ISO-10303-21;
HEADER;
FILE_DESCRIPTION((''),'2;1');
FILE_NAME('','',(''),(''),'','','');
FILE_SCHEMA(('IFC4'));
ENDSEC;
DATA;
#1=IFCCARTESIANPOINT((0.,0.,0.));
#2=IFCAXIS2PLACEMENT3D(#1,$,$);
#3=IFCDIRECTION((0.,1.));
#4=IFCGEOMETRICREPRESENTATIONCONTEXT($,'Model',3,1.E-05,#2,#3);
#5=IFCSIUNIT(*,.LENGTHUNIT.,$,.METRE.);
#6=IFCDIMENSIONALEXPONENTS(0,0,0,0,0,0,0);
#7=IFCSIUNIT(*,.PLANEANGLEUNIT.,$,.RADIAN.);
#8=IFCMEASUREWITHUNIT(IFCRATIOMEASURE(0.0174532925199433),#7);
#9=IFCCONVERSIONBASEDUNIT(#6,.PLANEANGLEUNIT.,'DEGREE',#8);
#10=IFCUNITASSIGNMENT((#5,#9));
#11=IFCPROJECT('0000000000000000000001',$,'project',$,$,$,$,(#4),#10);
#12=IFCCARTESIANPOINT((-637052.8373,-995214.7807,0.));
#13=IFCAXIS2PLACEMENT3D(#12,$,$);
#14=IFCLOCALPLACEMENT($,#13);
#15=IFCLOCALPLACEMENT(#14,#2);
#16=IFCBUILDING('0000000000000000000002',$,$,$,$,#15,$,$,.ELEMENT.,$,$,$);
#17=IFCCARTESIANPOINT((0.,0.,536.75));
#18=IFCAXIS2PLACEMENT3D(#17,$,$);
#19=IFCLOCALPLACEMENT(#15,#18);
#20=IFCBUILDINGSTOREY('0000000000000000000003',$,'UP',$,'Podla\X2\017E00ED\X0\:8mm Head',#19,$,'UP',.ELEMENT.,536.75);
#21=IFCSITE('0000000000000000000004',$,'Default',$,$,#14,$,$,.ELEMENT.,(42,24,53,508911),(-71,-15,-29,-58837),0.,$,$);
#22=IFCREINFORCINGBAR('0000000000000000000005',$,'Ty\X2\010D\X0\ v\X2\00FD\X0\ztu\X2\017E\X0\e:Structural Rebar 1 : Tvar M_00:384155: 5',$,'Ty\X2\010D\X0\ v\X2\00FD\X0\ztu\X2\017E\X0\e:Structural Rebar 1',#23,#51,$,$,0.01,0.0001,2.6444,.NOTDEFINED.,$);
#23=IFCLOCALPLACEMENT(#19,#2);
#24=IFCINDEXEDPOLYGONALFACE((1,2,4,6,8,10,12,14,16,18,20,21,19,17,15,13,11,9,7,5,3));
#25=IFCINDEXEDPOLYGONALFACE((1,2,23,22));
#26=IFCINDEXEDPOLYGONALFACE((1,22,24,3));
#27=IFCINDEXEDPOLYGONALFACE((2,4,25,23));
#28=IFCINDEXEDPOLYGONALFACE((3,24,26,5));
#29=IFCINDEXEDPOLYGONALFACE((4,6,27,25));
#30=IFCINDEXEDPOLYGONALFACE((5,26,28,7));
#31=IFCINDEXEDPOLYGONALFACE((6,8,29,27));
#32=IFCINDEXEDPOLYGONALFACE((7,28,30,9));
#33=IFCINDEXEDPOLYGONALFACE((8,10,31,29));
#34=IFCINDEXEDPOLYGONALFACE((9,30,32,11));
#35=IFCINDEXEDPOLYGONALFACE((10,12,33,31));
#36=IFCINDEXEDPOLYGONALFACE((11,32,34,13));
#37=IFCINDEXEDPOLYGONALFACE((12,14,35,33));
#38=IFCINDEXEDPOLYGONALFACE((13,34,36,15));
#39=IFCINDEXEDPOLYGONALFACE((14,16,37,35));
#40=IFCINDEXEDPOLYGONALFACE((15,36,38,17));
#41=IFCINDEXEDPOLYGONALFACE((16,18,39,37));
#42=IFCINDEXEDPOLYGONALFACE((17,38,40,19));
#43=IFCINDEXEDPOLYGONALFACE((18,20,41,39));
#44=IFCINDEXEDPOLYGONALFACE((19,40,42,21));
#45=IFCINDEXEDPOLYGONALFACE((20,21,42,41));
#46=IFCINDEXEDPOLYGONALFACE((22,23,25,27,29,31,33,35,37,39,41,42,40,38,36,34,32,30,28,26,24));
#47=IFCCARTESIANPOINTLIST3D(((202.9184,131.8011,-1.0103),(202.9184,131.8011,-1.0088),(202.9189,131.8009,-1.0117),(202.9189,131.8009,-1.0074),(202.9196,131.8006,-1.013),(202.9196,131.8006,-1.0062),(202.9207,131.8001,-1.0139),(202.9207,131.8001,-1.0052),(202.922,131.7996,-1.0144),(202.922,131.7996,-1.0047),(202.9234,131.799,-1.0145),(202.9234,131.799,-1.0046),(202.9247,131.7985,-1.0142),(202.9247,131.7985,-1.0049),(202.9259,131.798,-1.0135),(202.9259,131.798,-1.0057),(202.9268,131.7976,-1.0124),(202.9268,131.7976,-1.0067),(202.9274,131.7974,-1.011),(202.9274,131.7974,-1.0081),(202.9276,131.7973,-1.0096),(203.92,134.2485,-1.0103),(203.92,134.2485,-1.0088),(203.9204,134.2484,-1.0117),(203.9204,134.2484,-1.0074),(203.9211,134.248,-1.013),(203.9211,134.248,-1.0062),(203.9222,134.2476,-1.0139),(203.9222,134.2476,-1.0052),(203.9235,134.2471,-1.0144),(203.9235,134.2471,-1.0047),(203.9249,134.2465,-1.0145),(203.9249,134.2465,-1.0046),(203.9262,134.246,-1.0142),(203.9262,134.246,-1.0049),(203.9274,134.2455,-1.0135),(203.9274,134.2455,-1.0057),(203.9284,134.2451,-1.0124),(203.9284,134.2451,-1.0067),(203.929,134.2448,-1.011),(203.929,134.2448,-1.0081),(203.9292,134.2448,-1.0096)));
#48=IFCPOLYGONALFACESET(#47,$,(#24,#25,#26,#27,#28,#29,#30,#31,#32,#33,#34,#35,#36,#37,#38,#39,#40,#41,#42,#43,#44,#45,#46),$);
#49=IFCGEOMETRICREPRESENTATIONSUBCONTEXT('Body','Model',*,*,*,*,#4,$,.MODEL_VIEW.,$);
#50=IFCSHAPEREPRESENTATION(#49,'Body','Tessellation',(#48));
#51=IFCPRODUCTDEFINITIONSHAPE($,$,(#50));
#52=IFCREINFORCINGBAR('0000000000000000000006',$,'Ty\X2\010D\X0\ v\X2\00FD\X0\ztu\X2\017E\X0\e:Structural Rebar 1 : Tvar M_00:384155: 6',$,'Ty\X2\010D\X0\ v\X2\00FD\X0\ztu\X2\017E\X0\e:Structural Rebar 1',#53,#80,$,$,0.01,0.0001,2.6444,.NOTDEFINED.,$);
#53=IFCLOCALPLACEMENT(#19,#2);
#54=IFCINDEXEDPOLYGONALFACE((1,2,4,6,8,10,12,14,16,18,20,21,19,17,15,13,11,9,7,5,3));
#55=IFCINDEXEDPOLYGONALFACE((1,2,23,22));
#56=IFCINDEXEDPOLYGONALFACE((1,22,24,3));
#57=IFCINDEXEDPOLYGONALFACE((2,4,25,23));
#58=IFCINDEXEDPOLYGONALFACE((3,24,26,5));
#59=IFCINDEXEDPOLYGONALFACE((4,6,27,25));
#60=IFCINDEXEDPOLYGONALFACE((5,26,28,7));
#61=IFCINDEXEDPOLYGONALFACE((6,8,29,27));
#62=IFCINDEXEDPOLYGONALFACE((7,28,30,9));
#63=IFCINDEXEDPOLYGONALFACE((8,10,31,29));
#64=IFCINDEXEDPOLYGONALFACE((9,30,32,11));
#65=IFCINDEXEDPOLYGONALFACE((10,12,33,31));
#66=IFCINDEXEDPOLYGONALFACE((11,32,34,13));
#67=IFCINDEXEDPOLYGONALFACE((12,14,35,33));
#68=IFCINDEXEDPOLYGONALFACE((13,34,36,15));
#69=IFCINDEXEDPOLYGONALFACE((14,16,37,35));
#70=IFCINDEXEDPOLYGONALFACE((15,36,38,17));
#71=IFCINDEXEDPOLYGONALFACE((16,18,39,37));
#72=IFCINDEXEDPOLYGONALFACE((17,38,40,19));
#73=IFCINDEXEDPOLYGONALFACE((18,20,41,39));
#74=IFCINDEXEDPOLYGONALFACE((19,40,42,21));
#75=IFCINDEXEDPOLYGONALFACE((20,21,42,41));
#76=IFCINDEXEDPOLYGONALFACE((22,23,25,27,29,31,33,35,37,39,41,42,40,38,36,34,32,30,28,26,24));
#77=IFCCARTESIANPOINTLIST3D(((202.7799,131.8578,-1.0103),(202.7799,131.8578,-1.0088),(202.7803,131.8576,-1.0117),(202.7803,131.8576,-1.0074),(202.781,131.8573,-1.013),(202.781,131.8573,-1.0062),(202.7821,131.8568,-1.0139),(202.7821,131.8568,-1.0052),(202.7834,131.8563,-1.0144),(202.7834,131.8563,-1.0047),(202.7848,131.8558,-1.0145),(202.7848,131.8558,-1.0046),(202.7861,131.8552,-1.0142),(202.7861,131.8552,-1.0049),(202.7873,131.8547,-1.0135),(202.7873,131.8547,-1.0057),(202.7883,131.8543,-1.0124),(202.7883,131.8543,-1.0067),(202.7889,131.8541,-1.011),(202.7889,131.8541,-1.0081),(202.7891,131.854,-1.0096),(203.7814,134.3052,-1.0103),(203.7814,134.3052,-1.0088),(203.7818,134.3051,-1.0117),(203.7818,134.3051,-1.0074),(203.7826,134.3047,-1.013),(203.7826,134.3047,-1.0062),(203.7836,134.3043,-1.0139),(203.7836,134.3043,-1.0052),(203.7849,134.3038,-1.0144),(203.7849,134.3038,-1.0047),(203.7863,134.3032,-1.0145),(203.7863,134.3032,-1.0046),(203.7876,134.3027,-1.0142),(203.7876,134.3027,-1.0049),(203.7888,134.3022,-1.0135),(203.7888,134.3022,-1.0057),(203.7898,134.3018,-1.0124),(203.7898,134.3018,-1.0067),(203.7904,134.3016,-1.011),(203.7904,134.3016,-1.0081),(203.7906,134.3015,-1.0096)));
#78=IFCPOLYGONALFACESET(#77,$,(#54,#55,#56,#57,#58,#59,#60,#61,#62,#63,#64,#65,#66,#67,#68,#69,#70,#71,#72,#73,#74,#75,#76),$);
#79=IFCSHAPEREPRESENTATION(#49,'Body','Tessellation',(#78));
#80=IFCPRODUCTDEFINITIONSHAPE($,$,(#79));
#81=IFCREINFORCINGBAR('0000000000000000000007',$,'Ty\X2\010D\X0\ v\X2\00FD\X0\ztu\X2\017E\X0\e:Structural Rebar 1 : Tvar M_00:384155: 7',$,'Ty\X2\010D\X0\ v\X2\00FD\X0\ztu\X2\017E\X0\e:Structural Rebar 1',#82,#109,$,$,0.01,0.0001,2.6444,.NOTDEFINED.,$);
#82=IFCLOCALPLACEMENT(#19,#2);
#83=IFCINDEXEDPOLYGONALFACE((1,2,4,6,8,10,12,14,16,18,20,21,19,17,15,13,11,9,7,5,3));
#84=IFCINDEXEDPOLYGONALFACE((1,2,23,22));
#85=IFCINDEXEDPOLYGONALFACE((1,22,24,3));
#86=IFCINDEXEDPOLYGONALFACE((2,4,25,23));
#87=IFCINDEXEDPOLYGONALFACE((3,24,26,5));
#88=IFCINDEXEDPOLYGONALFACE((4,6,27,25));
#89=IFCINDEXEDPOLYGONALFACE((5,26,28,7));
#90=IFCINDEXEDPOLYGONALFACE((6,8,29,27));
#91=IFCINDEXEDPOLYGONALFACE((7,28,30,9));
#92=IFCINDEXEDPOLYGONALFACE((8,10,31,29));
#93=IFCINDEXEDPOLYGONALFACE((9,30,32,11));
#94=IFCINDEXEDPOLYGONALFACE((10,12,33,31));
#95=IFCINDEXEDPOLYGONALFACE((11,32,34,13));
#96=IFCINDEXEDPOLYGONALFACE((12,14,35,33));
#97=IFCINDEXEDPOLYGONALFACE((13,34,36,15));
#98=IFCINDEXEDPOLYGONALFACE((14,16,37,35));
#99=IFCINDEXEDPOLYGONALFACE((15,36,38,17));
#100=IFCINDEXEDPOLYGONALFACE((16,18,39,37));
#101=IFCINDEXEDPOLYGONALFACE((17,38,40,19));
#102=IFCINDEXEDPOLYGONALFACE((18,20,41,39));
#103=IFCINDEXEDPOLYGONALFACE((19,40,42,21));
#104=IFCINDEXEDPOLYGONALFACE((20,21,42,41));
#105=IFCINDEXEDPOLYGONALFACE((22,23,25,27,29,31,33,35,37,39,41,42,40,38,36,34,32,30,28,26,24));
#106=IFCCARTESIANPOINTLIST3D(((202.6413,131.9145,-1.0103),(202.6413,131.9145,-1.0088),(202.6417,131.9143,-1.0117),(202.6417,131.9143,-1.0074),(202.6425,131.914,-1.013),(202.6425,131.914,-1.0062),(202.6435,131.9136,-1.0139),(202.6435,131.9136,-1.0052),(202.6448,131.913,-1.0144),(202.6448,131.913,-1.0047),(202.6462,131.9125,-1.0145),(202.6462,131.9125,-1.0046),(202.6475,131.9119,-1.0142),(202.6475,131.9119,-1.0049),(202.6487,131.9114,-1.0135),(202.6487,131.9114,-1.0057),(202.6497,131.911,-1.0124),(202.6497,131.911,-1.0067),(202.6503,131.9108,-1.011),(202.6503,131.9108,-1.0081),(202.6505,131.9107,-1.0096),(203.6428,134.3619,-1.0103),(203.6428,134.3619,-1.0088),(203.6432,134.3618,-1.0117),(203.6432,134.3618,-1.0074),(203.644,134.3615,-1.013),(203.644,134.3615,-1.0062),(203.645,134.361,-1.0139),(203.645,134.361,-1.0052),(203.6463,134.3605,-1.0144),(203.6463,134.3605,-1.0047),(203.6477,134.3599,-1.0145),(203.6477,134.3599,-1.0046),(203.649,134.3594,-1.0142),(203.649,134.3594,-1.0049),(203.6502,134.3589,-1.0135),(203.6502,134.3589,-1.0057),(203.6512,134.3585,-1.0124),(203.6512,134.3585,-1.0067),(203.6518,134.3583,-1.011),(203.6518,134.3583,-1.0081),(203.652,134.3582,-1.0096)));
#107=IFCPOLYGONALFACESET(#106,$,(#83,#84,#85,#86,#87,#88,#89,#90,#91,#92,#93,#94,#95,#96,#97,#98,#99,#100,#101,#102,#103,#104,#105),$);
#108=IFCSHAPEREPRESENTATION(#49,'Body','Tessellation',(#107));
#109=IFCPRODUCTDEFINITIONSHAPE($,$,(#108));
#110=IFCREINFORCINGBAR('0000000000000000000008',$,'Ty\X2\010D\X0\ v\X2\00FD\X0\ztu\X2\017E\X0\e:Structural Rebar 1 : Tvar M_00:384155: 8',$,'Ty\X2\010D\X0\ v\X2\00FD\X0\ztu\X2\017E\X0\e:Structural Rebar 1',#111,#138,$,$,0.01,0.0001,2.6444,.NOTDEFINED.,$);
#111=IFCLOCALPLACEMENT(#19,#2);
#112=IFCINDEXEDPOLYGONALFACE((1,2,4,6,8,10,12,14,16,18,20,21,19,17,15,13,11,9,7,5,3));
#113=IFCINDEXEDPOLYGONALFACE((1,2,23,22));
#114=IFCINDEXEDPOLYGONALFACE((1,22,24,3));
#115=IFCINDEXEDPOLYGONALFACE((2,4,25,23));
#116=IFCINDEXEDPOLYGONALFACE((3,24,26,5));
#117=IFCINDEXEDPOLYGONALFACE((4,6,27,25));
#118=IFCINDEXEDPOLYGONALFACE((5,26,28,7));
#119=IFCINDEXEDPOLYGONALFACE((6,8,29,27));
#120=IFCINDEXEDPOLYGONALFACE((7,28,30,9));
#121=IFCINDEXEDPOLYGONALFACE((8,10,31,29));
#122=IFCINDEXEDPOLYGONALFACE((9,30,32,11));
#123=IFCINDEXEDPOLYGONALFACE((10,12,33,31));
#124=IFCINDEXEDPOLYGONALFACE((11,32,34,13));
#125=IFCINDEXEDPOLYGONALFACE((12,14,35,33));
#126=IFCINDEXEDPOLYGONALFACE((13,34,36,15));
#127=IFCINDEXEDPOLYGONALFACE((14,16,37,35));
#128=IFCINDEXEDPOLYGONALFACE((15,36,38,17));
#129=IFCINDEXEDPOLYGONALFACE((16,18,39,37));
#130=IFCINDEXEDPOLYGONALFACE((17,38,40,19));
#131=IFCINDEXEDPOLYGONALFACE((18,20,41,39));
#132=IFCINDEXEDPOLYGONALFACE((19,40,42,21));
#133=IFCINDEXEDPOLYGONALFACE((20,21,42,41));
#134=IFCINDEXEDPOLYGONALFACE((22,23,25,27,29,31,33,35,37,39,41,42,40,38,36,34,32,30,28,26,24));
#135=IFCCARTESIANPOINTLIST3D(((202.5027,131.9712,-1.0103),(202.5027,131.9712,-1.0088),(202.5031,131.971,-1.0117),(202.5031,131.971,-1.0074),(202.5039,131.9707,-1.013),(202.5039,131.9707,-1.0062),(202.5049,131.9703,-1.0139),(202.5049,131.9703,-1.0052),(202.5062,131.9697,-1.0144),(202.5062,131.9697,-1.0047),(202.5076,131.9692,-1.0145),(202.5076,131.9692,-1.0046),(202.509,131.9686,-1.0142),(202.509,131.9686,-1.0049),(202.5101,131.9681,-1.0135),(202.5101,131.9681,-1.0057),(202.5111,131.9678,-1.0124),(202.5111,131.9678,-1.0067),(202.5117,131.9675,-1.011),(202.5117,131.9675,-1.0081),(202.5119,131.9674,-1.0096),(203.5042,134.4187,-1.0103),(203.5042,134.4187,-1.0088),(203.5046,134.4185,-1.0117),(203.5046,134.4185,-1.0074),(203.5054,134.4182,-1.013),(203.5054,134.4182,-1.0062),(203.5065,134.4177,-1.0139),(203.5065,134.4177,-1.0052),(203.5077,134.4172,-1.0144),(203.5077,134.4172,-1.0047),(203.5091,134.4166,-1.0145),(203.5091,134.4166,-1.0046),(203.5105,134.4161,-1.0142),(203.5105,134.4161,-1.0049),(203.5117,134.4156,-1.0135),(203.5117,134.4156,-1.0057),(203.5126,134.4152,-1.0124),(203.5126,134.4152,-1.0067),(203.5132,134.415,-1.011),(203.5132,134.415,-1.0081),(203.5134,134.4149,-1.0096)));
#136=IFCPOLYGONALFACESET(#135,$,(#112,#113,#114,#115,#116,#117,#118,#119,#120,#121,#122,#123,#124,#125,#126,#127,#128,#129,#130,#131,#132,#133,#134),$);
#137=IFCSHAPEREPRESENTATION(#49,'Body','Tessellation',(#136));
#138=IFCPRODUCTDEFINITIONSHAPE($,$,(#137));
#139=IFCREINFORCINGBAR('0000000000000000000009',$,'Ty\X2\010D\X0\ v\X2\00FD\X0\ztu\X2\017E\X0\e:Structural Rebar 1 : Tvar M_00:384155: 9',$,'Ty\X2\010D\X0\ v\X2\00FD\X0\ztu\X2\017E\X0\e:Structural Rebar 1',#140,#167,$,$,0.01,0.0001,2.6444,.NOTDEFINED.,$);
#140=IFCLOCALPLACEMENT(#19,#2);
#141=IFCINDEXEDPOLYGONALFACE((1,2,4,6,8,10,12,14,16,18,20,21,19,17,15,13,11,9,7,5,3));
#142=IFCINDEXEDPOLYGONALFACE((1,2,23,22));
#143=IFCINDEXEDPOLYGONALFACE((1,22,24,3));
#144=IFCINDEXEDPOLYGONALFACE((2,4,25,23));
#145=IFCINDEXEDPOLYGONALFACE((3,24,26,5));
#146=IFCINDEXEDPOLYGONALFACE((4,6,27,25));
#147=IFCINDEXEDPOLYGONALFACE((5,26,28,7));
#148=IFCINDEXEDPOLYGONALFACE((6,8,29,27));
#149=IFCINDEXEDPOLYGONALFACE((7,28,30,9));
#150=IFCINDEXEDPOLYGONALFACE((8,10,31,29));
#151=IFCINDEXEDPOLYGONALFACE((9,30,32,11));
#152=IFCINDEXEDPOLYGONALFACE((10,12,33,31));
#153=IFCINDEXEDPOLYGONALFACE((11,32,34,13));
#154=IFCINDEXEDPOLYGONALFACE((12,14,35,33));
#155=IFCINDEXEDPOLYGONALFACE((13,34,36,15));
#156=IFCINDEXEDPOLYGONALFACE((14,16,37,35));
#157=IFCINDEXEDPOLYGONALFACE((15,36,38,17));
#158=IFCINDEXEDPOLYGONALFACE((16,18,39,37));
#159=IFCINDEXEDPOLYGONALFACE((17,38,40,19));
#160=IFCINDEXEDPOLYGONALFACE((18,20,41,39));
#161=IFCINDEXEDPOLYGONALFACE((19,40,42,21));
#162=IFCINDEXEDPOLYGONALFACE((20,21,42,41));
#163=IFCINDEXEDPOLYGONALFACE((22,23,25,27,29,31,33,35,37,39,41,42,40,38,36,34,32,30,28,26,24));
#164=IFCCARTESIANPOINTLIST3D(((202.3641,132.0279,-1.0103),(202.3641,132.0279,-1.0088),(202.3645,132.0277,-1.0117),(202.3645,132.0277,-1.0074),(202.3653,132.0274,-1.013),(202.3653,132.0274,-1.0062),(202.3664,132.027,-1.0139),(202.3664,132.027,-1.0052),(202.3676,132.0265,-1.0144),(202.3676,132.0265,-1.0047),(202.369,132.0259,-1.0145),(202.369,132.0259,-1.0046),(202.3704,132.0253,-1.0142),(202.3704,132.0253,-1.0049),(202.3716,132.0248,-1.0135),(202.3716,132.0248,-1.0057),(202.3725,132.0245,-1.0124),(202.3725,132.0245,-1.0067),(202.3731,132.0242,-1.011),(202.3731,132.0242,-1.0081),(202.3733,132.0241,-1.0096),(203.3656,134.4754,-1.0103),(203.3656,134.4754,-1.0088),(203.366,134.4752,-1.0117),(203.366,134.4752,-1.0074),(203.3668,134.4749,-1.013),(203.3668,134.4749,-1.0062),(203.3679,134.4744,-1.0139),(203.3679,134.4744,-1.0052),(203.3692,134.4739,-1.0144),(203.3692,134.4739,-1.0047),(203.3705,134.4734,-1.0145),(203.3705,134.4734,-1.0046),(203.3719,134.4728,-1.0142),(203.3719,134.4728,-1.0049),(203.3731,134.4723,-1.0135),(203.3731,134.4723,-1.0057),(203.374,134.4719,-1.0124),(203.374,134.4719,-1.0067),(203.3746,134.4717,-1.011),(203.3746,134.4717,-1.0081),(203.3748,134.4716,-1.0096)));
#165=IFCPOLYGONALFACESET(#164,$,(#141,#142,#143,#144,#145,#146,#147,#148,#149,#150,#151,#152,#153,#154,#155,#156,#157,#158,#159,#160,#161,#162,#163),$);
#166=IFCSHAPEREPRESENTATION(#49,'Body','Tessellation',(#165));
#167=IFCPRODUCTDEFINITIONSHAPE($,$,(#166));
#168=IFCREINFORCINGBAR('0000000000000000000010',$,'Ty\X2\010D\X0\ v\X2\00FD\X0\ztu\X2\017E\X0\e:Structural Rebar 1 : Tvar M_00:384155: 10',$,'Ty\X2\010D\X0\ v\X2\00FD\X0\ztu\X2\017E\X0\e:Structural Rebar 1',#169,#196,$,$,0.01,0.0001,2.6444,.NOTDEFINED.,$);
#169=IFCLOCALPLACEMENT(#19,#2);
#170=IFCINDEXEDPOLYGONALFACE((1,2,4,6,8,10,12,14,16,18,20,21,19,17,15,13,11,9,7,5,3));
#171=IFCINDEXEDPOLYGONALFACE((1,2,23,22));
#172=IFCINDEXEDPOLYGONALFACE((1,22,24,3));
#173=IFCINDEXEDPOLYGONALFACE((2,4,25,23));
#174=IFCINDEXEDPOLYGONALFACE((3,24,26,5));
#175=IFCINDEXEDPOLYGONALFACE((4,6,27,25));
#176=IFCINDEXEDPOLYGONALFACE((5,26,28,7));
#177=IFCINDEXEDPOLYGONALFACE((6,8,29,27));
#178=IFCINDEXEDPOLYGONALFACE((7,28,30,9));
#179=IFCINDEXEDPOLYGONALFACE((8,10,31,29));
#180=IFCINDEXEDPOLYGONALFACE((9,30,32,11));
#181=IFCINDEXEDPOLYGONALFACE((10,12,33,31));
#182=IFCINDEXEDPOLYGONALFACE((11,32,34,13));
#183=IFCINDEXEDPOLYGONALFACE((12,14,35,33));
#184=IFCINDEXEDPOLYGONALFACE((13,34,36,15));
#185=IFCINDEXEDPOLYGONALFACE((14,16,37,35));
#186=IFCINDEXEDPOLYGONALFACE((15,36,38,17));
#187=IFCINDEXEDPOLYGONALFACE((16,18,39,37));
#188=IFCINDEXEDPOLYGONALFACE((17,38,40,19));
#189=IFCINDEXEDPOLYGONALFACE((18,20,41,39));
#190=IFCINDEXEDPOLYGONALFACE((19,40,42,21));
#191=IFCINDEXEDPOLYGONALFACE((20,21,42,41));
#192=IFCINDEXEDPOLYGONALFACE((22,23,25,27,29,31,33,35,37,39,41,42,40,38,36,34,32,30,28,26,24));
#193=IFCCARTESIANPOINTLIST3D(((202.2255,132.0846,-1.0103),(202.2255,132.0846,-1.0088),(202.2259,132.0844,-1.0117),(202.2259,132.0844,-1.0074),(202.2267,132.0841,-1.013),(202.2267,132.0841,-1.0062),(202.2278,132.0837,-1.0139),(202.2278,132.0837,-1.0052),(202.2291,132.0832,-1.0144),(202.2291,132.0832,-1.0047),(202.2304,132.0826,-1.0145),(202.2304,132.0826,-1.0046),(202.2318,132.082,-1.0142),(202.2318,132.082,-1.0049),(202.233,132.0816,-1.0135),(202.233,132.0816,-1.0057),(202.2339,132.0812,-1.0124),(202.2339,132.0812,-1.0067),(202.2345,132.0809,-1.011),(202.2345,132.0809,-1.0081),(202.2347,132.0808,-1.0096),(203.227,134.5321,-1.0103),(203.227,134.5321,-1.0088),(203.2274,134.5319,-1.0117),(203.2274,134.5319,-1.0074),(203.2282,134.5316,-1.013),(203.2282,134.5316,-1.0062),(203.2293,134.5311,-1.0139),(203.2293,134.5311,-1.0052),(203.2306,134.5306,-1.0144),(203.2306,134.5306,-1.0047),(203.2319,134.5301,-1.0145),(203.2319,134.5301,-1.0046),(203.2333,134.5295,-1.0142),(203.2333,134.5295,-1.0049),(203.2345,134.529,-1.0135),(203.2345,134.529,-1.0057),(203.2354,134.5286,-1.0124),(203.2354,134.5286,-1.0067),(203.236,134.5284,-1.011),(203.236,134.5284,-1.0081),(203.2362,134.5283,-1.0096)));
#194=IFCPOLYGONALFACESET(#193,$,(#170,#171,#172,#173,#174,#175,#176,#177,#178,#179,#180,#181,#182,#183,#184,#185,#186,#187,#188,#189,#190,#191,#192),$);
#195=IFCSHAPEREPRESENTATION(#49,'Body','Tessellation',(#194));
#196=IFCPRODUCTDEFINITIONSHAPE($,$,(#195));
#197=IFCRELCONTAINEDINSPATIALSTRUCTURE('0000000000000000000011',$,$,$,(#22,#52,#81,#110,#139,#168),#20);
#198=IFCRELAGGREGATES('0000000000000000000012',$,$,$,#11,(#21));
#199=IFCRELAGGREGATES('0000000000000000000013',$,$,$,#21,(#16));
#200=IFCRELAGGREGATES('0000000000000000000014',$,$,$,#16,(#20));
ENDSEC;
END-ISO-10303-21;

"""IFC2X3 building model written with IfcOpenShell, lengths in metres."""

from ifc_helpers import new_model, entity, si_unit, converted_unit, direction, frame, origin, place, context, subcontext, project, spatial, element, save


model = new_model("IFC2X3")

# Units and contexts
model_context = context("Model", 3, precision=1e-05, world=origin(), true_north=direction((0.0, 1.0)))
body_context = subcontext(model_context, "Body", "Model", "MODEL_VIEW")
ifc_project = project(units=[si_unit("LENGTHUNIT", "METRE"), converted_unit("PLANEANGLEUNIT", "DEGREE", entity("IfcRatioMeasure", 0.0174532925199433), si_unit("PLANEANGLEUNIT", "RADIAN"), dimensions=[0, 0, 0, 0, 0, 0, 0])], contexts=[model_context])

# Site, building, storey
site_placement = place(None, frame((-637052.8373, -995214.7807, 0.0)))
site = spatial("IfcSite", under=ifc_project, at=site_placement, Name="Default", CompositionType="ELEMENT", RefLatitude=(42, 24, 53, 508911), RefLongitude=(-71, -15, -29, -58837), RefElevation=0.0)
building_placement = place(site_placement, origin())
building = spatial("IfcBuilding", under=site, at=building_placement, CompositionType="ELEMENT")
storey_placement = place(building_placement, frame((0.0, 0.0, 536.75)))
storey = spatial("IfcBuildingStorey", under=building, at=storey_placement, Name="UP", ObjectType="Podlaží:8mm Head", LongName="UP", CompositionType="ELEMENT", Elevation=536.75)

# Reinforcing bars
reinforcing_bar_1_placement = place(storey_placement, origin())
element("IfcReinforcingBar", 1, at=reinforcing_bar_1_placement, inside=storey, Name="Tyč výztuže:Structural Rebar 1 : Tvar M_00:384155: 5", ObjectType="Tyč výztuže:Structural Rebar 1", BarLength=2.6444, BarRole="NOTDEFINED", CrossSectionArea=0.0001, NominalDiameter=0.01, context=body_context, shape_type="AdvancedSweptSolid", body=[
    entity("IfcSweptDiskSolid", entity("IfcCompositeCurve", [entity("IfcCompositeCurveSegment", "CONTINUOUS", True, entity("IfcPolyline", [entity("IfcCartesianPoint", [-203.9245, -134.2467, 1.0096]), entity("IfcCartesianPoint", [-202.923, -131.7992, 1.0096])]))], False), 0.005, None, 0.0, 1.0),
])
reinforcing_bar_2_placement = place(storey_placement, origin())
element("IfcReinforcingBar", 2, at=reinforcing_bar_2_placement, inside=storey, Name="Tyč výztuže:Structural Rebar 1 : Tvar M_00:384155: 6", ObjectType="Tyč výztuže:Structural Rebar 1", BarLength=2.6444, BarRole="NOTDEFINED", CrossSectionArea=0.0001, NominalDiameter=0.01, context=body_context, shape_type="AdvancedSweptSolid", body=[
    entity("IfcSweptDiskSolid", entity("IfcCompositeCurve", [entity("IfcCompositeCurveSegment", "CONTINUOUS", True, entity("IfcPolyline", [entity("IfcCartesianPoint", [-203.7859, -134.3034, 1.0096]), entity("IfcCartesianPoint", [-202.7844, -131.8559, 1.0096])]))], False), 0.005, None, 0.0, 1.0),
])
reinforcing_bar_3_placement = place(storey_placement, origin())
element("IfcReinforcingBar", 3, at=reinforcing_bar_3_placement, inside=storey, Name="Tyč výztuže:Structural Rebar 1 : Tvar M_00:384155: 7", ObjectType="Tyč výztuže:Structural Rebar 1", BarLength=2.6444, BarRole="NOTDEFINED", CrossSectionArea=0.0001, NominalDiameter=0.01, context=body_context, shape_type="AdvancedSweptSolid", body=[
    entity("IfcSweptDiskSolid", entity("IfcCompositeCurve", [entity("IfcCompositeCurveSegment", "CONTINUOUS", True, entity("IfcPolyline", [entity("IfcCartesianPoint", [-203.6474, -134.3601, 1.0096]), entity("IfcCartesianPoint", [-202.6458, -131.9126, 1.0096])]))], False), 0.005, None, 0.0, 1.0),
])
reinforcing_bar_4_placement = place(storey_placement, origin())
element("IfcReinforcingBar", 4, at=reinforcing_bar_4_placement, inside=storey, Name="Tyč výztuže:Structural Rebar 1 : Tvar M_00:384155: 8", ObjectType="Tyč výztuže:Structural Rebar 1", BarLength=2.6444, BarRole="NOTDEFINED", CrossSectionArea=0.0001, NominalDiameter=0.01, context=body_context, shape_type="AdvancedSweptSolid", body=[
    entity("IfcSweptDiskSolid", entity("IfcCompositeCurve", [entity("IfcCompositeCurveSegment", "CONTINUOUS", True, entity("IfcPolyline", [entity("IfcCartesianPoint", [-203.5088, -134.4168, 1.0096]), entity("IfcCartesianPoint", [-202.5073, -131.9693, 1.0096])]))], False), 0.005, None, 0.0, 1.0),
])
reinforcing_bar_5_placement = place(storey_placement, origin())
element("IfcReinforcingBar", 5, at=reinforcing_bar_5_placement, inside=storey, Name="Tyč výztuže:Structural Rebar 1 : Tvar M_00:384155: 9", ObjectType="Tyč výztuže:Structural Rebar 1", BarLength=2.6444, BarRole="NOTDEFINED", CrossSectionArea=0.0001, NominalDiameter=0.01, context=body_context, shape_type="AdvancedSweptSolid", body=[
    entity("IfcSweptDiskSolid", entity("IfcCompositeCurve", [entity("IfcCompositeCurveSegment", "CONTINUOUS", True, entity("IfcPolyline", [entity("IfcCartesianPoint", [-203.3702, -134.4735, 1.0096]), entity("IfcCartesianPoint", [-202.3687, -132.026, 1.0096])]))], False), 0.005, None, 0.0, 1.0),
])
reinforcing_bar_6_placement = place(storey_placement, origin())
element("IfcReinforcingBar", 6, at=reinforcing_bar_6_placement, inside=storey, Name="Tyč výztuže:Structural Rebar 1 : Tvar M_00:384155: 10", ObjectType="Tyč výztuže:Structural Rebar 1", BarLength=2.6444, BarRole="NOTDEFINED", CrossSectionArea=0.0001, NominalDiameter=0.01, context=body_context, shape_type="AdvancedSweptSolid", body=[
    entity("IfcSweptDiskSolid", entity("IfcCompositeCurve", [entity("IfcCompositeCurveSegment", "CONTINUOUS", True, entity("IfcPolyline", [entity("IfcCartesianPoint", [-203.2316, -134.5302, 1.0096]), entity("IfcCartesianPoint", [-202.2301, -132.0827, 1.0096])]))], False), 0.005, None, 0.0, 1.0),
])

save(model, "model.ifc")
